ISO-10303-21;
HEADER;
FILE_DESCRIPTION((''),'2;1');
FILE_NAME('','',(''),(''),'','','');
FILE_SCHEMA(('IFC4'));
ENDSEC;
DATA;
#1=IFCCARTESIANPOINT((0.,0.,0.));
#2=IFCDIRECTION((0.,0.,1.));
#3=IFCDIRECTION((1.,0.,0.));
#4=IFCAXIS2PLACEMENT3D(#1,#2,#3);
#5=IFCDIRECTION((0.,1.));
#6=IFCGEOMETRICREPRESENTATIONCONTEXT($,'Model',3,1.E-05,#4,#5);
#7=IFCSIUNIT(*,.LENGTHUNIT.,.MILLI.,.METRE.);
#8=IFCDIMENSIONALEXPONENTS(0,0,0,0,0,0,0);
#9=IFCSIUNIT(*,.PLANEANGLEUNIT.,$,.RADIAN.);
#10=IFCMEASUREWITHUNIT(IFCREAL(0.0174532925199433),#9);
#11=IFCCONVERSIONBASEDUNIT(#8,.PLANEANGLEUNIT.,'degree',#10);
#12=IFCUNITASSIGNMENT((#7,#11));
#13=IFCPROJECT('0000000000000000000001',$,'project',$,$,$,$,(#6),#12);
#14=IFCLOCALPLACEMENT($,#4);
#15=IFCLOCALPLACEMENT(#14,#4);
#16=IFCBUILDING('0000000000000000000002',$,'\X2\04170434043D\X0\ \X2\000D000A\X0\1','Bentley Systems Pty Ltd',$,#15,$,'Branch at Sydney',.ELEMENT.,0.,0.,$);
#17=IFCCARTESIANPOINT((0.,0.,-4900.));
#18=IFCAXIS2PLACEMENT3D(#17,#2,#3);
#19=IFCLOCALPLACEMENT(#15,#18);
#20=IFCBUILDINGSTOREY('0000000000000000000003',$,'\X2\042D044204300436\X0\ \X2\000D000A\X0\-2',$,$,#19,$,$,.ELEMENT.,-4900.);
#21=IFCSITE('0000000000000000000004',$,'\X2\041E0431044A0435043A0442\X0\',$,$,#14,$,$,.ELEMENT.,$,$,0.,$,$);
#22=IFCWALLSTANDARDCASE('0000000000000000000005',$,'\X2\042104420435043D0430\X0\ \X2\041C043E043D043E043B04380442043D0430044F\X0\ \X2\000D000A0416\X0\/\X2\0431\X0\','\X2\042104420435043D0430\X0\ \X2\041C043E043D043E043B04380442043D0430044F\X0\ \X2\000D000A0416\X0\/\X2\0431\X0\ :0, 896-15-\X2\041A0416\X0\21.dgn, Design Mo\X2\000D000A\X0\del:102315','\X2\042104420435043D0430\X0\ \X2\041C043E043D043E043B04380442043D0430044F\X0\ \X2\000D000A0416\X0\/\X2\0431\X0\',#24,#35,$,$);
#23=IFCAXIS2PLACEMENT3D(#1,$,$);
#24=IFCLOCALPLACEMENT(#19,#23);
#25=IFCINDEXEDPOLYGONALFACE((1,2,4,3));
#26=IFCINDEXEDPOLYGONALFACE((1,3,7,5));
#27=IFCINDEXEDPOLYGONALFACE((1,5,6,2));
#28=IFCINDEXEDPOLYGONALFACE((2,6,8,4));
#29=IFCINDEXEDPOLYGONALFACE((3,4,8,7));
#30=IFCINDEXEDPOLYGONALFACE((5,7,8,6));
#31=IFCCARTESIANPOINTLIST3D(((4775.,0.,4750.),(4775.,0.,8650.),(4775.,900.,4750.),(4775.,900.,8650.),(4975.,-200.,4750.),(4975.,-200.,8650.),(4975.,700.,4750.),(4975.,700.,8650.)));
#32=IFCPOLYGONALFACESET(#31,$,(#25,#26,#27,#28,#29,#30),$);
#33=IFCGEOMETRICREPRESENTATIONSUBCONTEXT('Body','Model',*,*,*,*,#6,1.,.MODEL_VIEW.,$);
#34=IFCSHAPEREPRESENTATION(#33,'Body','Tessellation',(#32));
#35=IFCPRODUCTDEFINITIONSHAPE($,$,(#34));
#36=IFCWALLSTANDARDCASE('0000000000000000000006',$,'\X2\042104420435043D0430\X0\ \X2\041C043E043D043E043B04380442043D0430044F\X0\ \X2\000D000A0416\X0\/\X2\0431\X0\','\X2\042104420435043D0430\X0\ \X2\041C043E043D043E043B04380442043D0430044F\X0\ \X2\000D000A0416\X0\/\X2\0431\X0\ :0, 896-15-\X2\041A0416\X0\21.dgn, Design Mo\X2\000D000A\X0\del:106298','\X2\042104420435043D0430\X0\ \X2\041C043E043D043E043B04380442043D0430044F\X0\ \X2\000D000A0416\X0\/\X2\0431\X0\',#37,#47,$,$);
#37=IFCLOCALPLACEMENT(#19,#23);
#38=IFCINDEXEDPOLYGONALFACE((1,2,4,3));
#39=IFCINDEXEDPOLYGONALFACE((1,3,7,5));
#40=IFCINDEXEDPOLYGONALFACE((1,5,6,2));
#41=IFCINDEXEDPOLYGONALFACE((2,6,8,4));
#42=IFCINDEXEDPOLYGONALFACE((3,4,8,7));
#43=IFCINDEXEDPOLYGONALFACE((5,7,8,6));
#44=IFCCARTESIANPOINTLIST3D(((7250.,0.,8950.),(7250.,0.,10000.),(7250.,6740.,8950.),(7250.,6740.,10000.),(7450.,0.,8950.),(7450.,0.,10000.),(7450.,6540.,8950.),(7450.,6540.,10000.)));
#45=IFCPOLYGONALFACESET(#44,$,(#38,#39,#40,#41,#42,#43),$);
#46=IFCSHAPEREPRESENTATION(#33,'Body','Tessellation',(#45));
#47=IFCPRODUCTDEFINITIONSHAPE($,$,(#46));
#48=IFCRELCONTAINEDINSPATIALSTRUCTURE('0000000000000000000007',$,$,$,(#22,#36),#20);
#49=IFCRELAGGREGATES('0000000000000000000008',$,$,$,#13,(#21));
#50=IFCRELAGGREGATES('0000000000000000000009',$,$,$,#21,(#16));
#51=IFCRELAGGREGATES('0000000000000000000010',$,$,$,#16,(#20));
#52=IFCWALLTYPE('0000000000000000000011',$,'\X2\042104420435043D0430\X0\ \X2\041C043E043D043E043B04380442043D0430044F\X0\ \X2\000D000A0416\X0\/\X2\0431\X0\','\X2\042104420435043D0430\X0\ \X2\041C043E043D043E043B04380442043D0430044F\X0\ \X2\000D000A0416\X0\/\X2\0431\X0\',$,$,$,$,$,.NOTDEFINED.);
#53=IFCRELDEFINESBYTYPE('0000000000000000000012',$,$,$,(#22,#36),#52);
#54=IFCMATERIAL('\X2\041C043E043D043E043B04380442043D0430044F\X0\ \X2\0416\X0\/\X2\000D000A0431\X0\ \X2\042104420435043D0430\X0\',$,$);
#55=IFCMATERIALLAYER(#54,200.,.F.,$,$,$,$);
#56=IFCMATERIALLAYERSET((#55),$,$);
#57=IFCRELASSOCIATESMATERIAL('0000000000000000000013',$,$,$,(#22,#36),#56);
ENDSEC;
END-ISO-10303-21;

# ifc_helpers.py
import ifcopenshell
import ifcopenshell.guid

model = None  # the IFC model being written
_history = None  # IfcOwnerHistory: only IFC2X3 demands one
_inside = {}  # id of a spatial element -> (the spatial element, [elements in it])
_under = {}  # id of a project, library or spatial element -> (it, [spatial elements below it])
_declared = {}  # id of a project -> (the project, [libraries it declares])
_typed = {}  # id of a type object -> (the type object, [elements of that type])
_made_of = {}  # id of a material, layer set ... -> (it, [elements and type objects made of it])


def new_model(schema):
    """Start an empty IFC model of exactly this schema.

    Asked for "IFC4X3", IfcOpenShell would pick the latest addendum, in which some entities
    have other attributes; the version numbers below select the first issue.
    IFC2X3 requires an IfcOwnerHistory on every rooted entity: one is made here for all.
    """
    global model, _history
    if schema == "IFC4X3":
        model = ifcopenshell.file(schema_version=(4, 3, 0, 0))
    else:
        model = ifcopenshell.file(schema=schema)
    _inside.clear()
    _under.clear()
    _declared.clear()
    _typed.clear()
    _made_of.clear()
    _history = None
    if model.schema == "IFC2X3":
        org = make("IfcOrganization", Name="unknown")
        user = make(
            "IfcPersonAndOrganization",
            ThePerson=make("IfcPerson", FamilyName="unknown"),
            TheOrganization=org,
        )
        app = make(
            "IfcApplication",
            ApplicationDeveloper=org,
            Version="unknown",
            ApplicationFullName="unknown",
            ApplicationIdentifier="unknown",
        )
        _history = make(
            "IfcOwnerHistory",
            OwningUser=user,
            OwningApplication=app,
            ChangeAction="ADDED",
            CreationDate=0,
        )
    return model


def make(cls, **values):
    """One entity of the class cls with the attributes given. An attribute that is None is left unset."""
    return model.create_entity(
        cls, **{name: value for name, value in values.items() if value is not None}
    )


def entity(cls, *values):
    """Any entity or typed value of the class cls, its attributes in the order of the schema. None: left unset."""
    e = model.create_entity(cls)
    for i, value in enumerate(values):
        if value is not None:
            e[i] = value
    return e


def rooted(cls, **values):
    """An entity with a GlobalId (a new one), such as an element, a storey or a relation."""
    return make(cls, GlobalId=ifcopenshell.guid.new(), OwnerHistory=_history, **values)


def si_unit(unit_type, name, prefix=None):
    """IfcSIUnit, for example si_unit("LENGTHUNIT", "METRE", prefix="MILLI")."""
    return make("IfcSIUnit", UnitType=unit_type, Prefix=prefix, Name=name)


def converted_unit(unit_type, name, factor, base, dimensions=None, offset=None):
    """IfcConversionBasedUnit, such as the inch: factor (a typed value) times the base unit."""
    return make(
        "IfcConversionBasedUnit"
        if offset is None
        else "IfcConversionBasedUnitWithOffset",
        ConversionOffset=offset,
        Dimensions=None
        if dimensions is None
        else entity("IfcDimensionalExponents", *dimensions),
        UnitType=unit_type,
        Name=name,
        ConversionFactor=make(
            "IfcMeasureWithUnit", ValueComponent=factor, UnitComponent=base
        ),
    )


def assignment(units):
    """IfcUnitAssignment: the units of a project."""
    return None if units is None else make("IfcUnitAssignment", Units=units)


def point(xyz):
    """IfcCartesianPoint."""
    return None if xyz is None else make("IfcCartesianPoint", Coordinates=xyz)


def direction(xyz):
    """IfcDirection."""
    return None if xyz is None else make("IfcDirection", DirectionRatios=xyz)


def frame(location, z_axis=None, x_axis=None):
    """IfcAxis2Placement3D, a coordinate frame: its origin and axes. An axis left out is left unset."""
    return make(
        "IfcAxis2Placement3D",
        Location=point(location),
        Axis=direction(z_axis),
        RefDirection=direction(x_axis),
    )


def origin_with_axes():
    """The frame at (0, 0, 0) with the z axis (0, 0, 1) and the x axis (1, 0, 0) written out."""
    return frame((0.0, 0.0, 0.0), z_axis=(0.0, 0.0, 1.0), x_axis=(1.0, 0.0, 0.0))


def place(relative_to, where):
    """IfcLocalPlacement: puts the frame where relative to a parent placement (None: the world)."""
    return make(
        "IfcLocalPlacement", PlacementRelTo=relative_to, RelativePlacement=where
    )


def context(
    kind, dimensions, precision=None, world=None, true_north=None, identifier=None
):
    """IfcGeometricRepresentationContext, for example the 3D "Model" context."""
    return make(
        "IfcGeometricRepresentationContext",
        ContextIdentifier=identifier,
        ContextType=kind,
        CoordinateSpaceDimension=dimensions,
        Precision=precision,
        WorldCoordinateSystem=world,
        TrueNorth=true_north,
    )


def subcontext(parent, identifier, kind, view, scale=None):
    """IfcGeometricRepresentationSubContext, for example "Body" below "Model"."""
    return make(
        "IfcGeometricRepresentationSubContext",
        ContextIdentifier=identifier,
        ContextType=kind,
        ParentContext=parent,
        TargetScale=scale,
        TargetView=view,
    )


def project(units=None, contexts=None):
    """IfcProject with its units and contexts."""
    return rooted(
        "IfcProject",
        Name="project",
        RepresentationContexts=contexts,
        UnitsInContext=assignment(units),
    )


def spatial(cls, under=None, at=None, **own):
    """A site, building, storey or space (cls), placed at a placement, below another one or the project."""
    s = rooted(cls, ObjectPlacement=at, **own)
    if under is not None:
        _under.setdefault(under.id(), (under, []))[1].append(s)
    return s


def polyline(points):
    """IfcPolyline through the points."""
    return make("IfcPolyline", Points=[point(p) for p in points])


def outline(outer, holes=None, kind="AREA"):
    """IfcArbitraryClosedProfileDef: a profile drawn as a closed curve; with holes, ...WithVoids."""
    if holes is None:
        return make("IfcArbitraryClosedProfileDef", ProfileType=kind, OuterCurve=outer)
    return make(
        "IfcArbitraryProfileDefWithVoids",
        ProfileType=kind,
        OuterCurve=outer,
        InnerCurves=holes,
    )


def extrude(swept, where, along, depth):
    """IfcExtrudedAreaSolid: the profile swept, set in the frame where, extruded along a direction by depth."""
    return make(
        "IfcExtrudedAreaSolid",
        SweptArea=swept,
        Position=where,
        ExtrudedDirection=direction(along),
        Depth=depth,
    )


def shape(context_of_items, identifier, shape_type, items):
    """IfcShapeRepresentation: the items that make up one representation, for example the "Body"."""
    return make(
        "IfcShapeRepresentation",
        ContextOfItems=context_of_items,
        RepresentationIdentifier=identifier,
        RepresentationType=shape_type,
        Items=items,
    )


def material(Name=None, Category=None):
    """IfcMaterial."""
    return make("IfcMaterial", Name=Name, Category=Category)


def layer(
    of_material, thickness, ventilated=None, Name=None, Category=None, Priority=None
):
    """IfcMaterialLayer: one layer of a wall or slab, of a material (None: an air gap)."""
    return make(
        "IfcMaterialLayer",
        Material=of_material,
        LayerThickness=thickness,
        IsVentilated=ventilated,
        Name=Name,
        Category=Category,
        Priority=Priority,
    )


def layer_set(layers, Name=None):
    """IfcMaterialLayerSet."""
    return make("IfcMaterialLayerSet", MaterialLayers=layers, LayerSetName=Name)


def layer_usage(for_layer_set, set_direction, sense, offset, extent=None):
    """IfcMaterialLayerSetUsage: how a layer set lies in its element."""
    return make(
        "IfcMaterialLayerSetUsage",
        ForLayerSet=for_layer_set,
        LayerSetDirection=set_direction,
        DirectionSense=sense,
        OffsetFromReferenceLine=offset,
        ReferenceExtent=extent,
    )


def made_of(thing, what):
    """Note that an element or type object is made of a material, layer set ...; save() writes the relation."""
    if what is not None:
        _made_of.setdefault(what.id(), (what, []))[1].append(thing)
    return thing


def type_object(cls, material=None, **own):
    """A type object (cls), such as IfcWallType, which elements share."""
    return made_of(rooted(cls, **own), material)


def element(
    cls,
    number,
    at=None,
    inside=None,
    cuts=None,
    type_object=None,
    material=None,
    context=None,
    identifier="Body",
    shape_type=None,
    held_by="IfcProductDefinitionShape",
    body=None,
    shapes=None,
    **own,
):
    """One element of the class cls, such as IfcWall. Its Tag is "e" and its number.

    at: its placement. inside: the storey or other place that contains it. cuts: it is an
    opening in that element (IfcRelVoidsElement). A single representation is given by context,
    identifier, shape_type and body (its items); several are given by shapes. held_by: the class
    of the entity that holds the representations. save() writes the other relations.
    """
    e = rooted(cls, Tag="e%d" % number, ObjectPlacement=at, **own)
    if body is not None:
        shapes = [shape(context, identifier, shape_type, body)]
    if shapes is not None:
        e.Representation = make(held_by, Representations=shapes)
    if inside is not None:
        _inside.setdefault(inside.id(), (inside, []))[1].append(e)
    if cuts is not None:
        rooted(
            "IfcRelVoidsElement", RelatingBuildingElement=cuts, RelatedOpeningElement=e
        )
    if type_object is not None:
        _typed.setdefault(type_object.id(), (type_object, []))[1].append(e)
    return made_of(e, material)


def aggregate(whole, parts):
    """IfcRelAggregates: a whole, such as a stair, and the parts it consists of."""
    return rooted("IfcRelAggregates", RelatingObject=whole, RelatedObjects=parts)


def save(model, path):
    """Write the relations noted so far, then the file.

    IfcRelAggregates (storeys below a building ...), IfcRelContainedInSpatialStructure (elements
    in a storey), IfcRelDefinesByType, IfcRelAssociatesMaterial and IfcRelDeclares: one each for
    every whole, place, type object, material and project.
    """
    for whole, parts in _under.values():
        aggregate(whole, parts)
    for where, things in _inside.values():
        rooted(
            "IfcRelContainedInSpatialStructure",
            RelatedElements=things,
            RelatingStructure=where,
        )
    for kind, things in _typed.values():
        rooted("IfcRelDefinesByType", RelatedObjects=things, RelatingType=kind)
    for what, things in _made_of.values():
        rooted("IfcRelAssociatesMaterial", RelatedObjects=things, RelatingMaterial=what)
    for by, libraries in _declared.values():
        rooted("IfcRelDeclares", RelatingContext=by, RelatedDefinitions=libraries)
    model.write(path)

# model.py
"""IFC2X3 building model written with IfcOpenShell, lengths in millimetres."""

from ifc_helpers import new_model, entity, si_unit, converted_unit, direction, frame, origin_with_axes, place, context, subcontext, project, spatial, polyline, outline, extrude, material, layer, layer_set, layer_usage, type_object, element, save


model = new_model("IFC2X3")

# Units and contexts
model_context = context("Model", 3, precision=1e-05, world=origin_with_axes(), true_north=direction((0.0, 1.0)))
body_context = subcontext(model_context, "Body", "Model", "MODEL_VIEW", scale=1.0)
ifc_project = project(units=[si_unit("LENGTHUNIT", "METRE", prefix="MILLI"), converted_unit("PLANEANGLEUNIT", "degree", entity("IfcReal", 0.0174532925199433), si_unit("PLANEANGLEUNIT", "RADIAN"), dimensions=[0, 0, 0, 0, 0, 0, 0])], contexts=[model_context])

# Site, building, storey
site_placement = place(None, origin_with_axes())
site = spatial("IfcSite", under=ifc_project, at=site_placement, Name="Объект", CompositionType="ELEMENT", RefElevation=0.0)
building_placement = place(site_placement, origin_with_axes())
building = spatial("IfcBuilding", under=site, at=building_placement, Name="Здн \r\n1", Description="Bentley Systems Pty Ltd", LongName="Branch at Sydney", CompositionType="ELEMENT", ElevationOfRefHeight=0.0, ElevationOfTerrain=0.0)
storey_placement = place(building_placement, frame((0.0, 0.0, -4900.0), z_axis=(0.0, 0.0, 1.0), x_axis=(1.0, 0.0, 0.0)))
storey = spatial("IfcBuildingStorey", under=building, at=storey_placement, Name="Этаж \r\n-2", CompositionType="ELEMENT", Elevation=-4900.0)

# Shared definitions
ifc_material_1 = material(Name="Монолитная Ж/\r\nб Стена")
wall_type = type_object("IfcWallType", Name="Стена Монолитная \r\nЖ/б", Description="Стена Монолитная \r\nЖ/б", PredefinedType="NOTDEFINED")
ifc_layer_1 = layer(ifc_material_1, 200.0, ventilated=False)
ifc_layer_set_1 = layer_set([ifc_layer_1])
ifc_layer_usage_1 = layer_usage(ifc_layer_set_1, "AXIS2", "POSITIVE", 0.0)

# Walls
wall_1_placement = place(storey_placement, frame((4975.0, -200.0, 4750.0), z_axis=(0.0, 0.0, 1.0), x_axis=(0.0, 1.0, 0.0)))
element("IfcWallStandardCase", 1, at=wall_1_placement, inside=storey, type_object=wall_type, material=ifc_layer_usage_1, Name="Стена Монолитная \r\nЖ/б", Description="Стена Монолитная \r\nЖ/б :0, 896-15-КЖ21.dgn, Design Mo\r\ndel:102315", ObjectType="Стена Монолитная \r\nЖ/б", context=body_context, shape_type="SweptSolid", body=[
    extrude(outline(polyline([(1100.0, 200.0), (200.0, 200.0), (0.0, 0.0), (900.0, 0.0), (1100.0, 200.0)])), origin_with_axes(), (0.0, 0.0, 1.0), 3900.0),
])
wall_2_placement = place(storey_placement, frame((7250.0, 0.0, 8950.0), z_axis=(0.0, 0.0, 1.0), x_axis=(0.0, 1.0, 0.0)))
element("IfcWallStandardCase", 2, at=wall_2_placement, inside=storey, type_object=wall_type, material=ifc_layer_usage_1, Name="Стена Монолитная \r\nЖ/б", Description="Стена Монолитная \r\nЖ/б :0, 896-15-КЖ21.dgn, Design Mo\r\ndel:106298", ObjectType="Стена Монолитная \r\nЖ/б", context=body_context, shape_type="SweptSolid", body=[
    extrude(outline(polyline([(6740.0, 0.0), (0.0, 0.0), (0.0, -200.0), (6540.0, -200.0), (6740.0, 0.0)])), origin_with_axes(), (0.0, 0.0, 1.0), 1050.0),
])

save(model, "model.ifc")
